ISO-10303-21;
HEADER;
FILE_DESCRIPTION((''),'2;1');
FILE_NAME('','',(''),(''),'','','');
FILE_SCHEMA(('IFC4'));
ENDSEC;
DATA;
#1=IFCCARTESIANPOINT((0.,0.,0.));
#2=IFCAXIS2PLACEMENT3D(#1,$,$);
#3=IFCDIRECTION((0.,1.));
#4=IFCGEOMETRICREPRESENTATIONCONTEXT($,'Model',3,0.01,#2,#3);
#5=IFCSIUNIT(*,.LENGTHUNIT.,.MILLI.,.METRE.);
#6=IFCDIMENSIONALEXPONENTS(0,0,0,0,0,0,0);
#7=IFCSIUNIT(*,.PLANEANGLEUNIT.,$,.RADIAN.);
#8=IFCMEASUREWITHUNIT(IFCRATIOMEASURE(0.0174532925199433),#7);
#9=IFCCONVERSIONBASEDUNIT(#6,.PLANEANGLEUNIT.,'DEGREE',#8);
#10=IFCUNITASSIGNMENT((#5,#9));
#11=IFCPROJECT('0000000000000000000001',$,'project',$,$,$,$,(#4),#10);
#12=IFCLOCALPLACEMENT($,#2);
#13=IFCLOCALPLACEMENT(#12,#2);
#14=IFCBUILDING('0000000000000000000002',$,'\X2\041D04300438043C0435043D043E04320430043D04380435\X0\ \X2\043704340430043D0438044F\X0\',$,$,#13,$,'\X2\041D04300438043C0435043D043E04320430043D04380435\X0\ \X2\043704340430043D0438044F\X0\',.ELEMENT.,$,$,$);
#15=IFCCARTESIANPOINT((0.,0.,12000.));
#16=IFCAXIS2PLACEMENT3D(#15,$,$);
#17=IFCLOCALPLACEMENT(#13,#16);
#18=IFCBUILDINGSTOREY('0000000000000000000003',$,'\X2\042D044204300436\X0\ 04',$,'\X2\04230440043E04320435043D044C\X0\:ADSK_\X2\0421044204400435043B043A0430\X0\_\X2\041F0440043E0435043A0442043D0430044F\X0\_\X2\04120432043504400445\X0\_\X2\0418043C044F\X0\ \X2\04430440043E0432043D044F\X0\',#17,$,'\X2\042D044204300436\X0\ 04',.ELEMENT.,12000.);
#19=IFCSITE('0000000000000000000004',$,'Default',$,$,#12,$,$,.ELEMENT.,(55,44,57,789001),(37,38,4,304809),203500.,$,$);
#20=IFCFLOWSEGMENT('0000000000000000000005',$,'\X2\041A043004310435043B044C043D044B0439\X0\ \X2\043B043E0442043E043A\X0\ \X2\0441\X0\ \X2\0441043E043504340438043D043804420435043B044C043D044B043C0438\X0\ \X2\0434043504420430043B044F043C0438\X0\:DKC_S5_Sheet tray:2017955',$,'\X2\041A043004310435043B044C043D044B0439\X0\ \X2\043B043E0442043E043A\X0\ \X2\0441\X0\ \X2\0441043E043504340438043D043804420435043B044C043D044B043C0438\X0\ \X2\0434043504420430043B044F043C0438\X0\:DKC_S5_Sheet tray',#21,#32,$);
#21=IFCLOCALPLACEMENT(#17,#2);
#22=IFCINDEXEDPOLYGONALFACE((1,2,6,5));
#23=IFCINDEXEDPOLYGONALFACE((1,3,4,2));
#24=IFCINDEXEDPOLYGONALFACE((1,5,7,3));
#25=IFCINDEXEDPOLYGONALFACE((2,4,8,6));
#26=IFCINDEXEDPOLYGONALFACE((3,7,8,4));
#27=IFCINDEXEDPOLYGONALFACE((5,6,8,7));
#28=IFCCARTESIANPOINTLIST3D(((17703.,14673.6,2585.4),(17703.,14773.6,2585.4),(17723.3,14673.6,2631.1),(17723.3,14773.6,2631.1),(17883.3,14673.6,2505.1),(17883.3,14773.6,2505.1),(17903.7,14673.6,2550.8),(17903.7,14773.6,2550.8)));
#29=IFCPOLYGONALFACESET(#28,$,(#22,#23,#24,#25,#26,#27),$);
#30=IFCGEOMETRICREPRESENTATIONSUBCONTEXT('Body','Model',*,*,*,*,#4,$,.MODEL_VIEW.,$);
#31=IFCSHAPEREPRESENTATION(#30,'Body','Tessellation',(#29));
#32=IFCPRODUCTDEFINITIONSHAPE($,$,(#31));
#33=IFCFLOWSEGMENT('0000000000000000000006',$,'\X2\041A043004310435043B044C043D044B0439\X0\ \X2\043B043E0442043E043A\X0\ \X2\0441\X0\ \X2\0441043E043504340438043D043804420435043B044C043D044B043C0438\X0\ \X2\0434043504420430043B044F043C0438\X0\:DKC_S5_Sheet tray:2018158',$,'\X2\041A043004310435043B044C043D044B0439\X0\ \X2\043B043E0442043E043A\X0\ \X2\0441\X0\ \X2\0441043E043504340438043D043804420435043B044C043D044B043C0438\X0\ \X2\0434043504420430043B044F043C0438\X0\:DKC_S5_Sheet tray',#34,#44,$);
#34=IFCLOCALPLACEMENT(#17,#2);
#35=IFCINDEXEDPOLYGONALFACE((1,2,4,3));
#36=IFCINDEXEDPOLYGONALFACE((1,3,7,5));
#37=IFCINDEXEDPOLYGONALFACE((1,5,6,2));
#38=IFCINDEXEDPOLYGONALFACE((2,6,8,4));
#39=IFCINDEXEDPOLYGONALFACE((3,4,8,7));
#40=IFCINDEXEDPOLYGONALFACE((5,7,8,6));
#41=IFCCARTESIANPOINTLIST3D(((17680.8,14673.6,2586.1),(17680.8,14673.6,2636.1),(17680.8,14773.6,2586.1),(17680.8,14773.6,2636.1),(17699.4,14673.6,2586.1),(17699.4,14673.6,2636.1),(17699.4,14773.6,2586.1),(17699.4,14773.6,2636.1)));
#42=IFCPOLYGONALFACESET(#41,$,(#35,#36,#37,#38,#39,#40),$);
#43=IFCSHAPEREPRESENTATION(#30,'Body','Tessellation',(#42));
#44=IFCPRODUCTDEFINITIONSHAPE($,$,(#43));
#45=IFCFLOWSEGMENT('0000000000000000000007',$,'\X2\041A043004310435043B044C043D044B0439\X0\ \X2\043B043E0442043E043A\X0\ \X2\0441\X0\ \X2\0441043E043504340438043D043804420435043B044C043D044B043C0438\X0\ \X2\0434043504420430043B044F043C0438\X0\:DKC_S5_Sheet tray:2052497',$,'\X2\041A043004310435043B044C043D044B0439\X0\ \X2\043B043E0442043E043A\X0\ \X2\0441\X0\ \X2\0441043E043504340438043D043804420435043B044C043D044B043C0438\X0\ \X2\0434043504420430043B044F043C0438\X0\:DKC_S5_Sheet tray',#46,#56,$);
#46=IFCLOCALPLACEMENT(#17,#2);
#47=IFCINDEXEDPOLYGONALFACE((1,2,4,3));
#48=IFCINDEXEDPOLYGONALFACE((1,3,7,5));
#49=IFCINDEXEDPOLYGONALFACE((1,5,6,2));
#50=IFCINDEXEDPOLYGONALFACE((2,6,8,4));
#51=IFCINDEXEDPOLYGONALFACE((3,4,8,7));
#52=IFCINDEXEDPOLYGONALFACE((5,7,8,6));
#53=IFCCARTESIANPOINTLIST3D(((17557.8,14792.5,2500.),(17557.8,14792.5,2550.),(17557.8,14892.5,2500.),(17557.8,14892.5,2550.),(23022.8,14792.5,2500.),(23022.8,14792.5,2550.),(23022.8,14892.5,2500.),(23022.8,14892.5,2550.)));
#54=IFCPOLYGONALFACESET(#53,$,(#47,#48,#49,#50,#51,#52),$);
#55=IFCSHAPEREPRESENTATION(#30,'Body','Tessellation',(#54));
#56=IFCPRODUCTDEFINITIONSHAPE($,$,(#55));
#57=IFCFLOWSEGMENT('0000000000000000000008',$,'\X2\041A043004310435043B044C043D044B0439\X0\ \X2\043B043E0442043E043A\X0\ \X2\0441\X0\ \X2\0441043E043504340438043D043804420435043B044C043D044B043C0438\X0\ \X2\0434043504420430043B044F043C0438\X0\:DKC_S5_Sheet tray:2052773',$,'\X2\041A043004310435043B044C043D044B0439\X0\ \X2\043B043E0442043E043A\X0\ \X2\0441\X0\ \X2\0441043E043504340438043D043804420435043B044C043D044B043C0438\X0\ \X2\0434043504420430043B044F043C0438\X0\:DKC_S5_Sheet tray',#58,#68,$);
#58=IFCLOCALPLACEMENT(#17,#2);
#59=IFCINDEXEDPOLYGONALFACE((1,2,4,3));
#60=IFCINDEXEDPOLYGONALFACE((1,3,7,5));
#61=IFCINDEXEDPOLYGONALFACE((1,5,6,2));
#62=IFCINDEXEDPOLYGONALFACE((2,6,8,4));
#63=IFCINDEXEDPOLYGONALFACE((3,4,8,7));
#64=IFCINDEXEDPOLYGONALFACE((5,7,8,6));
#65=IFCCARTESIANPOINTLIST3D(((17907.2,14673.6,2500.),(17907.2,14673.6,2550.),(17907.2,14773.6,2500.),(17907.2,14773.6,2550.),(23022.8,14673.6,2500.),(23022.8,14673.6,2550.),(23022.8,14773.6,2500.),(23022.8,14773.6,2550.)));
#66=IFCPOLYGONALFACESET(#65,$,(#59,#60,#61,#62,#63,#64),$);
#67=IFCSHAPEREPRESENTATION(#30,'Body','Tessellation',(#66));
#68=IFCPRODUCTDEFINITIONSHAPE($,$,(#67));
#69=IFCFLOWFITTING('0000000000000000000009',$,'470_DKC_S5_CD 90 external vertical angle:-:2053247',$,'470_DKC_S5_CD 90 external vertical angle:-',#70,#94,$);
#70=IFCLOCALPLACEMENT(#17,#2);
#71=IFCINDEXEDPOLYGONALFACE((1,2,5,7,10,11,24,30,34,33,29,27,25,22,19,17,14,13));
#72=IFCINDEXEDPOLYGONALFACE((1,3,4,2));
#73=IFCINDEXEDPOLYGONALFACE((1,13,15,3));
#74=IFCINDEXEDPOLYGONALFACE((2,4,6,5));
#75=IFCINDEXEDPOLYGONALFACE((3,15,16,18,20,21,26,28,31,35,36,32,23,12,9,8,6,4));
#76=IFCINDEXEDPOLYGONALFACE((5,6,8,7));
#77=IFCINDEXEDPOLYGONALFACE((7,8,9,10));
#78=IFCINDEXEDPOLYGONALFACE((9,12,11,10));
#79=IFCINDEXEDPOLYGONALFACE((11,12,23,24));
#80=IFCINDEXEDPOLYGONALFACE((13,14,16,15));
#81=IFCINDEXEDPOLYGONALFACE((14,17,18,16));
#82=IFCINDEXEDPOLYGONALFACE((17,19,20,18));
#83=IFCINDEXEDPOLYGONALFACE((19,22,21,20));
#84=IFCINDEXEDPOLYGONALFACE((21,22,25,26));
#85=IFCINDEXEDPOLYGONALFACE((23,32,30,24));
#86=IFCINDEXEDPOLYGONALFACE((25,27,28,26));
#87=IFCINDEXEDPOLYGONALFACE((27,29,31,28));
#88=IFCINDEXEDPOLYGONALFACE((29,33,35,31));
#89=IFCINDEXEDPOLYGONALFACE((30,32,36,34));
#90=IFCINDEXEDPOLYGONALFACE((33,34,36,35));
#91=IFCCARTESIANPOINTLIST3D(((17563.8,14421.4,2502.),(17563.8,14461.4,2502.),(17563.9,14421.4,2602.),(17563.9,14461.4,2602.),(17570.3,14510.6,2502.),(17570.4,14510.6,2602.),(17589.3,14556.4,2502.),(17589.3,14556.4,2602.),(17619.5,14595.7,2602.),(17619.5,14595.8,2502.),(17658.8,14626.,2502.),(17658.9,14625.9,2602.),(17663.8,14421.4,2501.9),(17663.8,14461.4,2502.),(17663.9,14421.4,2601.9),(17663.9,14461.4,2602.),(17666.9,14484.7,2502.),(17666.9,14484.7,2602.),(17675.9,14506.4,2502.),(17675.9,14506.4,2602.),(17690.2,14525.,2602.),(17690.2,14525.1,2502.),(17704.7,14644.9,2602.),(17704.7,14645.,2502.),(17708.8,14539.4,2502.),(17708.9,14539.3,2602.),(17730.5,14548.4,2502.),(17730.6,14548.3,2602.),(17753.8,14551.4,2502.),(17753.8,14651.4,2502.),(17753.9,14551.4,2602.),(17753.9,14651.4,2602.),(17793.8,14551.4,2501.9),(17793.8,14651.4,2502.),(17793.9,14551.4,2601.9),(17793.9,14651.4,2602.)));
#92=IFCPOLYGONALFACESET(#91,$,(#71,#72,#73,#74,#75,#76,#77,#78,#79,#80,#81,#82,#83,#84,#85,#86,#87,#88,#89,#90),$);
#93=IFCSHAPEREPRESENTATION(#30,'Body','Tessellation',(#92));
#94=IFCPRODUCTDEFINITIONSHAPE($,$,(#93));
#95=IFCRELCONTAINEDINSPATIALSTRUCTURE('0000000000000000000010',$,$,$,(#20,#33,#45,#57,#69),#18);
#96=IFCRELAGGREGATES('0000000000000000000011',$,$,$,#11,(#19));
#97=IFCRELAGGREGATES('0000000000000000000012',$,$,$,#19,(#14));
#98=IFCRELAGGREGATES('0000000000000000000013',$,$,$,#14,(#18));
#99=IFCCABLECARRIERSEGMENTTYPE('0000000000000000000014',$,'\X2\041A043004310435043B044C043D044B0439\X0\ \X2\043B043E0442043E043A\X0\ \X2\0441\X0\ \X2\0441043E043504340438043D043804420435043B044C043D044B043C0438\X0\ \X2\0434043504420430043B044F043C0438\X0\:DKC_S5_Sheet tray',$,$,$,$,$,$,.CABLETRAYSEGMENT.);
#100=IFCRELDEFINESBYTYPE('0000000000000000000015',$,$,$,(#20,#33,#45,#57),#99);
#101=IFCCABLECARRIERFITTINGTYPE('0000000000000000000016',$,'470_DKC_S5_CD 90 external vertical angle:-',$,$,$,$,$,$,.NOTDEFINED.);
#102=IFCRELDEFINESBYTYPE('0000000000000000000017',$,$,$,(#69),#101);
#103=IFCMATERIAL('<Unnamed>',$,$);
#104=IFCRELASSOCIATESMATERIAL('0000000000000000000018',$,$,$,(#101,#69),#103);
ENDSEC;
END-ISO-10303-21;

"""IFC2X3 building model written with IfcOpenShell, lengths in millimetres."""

from ifc_helpers import new_model, entity, si_unit, converted_unit, direction, frame, frame_2d, origin, origin_2d_with_axis, place, context, subcontext, project, spatial, polyline, circle_curve, parameter, trimmed, segment, composite_curve, rectangle, outline, extrude, source, transform, mapped, material, type_object, type_shapes, element, save


model = new_model("IFC2X3")

# Units and contexts
model_context = context("Model", 3, precision=0.01, world=origin(), true_north=direction((0.0, 1.0)))
body_context = subcontext(model_context, "Body", "Model", "MODEL_VIEW")
ifc_project = project(units=[si_unit("LENGTHUNIT", "METRE", prefix="MILLI"), converted_unit("PLANEANGLEUNIT", "DEGREE", entity("IfcRatioMeasure", 0.0174532925199433), si_unit("PLANEANGLEUNIT", "RADIAN"), dimensions=[0, 0, 0, 0, 0, 0, 0])], contexts=[model_context])

# Site, building, storey
site_placement = place(None, origin())
site = spatial("IfcSite", under=ifc_project, at=site_placement, Name="Default", CompositionType="ELEMENT", RefLatitude=(55, 44, 57, 789001), RefLongitude=(37, 38, 4, 304809), RefElevation=203500.0)
building_placement = place(site_placement, origin())
building = spatial("IfcBuilding", under=site, at=building_placement, Name="Наименование здания", LongName="Наименование здания", CompositionType="ELEMENT")
storey_placement = place(building_placement, frame((0.0, 0.0, 12000.0)))
storey = spatial("IfcBuildingStorey", under=building, at=storey_placement, Name="Этаж 04", ObjectType="Уровень:ADSK_Стрелка_Проектная_Вверх_Имя уровня", LongName="Этаж 04", CompositionType="ELEMENT", Elevation=12000.0)

# Flow segments
cable_carrier_segment_type = type_object("IfcCableCarrierSegmentType", Name="Кабельный лоток с соединительными деталями:DKC_S5_Sheet tray", PredefinedType="CABLETRAYSEGMENT")
flow_segment_1_placement = place(storey_placement, frame((17703.0, 14673.6, 2505.1)))
element("IfcFlowSegment", 1, at=flow_segment_1_placement, inside=storey, type_object=cable_carrier_segment_type, Name="Кабельный лоток с соединительными деталями:DKC_S5_Sheet tray:2017955", ObjectType="Кабельный лоток с соединительными деталями:DKC_S5_Sheet tray", context=body_context, shape_type="SweptSolid", body=[
    extrude(rectangle(XDim=50.0, YDim=100.0, at=origin_2d_with_axis()), frame((10.2, 50.0, 103.1), z_axis=(0.913545, 0.0, -0.406737), x_axis=(0.406737, 0.0, 0.913545)), (0.0, 0.0, 1.0), 197.4),
])
flow_segment_2_placement = place(storey_placement, frame((17680.8, 14673.6, 2586.1)))
element("IfcFlowSegment", 2, at=flow_segment_2_placement, inside=storey, type_object=cable_carrier_segment_type, Name="Кабельный лоток с соединительными деталями:DKC_S5_Sheet tray:2018158", ObjectType="Кабельный лоток с соединительными деталями:DKC_S5_Sheet tray", context=body_context, shape_type="SweptSolid", body=[
    extrude(rectangle(XDim=18.6, YDim=100.0, at=origin_2d_with_axis()), frame((9.3, 50.0, 0.0), z_axis=(0.0, 0.0, 1.0), x_axis=(-1.0, 0.0, 0.0)), (0.0, 0.0, 1.0), 50.0),
])
flow_segment_3_placement = place(storey_placement, frame((17557.8, 14792.5, 2500.0)))
element("IfcFlowSegment", 3, at=flow_segment_3_placement, inside=storey, type_object=cable_carrier_segment_type, Name="Кабельный лоток с соединительными деталями:DKC_S5_Sheet tray:2052497", ObjectType="Кабельный лоток с соединительными деталями:DKC_S5_Sheet tray", context=body_context, shape_type="SweptSolid", body=[
    extrude(rectangle(XDim=5465.1, YDim=100.0, at=origin_2d_with_axis()), frame((2732.5, 50.0, 0.0)), (0.0, 0.0, 1.0), 50.0),
])
flow_segment_4_placement = place(storey_placement, frame((17907.2, 14673.6, 2500.0)))
element("IfcFlowSegment", 4, at=flow_segment_4_placement, inside=storey, type_object=cable_carrier_segment_type, Name="Кабельный лоток с соединительными деталями:DKC_S5_Sheet tray:2052773", ObjectType="Кабельный лоток с соединительными деталями:DKC_S5_Sheet tray", context=body_context, shape_type="SweptSolid", body=[
    extrude(rectangle(XDim=5115.6, YDim=100.0, at=origin_2d_with_axis()), frame((2557.8, 50.0, 0.0)), (0.0, 0.0, 1.0), 50.0),
])

# Flow fitting
ifc_material_1 = material(Name="<Unnamed>")
cable_carrier_fitting_type_1 = type_object("IfcCableCarrierFittingType", Name="470_DKC_S5_CD 90 external vertical angle:-", PredefinedType="NOTDEFINED", material=ifc_material_1)
shared_shape_1 = source(origin(), body_context, "Body", "SweptSolid", [
    extrude(outline(composite_curve([segment(polyline([(-100.0, -130.0), (-60.0, -130.0)]), True, "CONTINUOUS"), segment(trimmed(circle_curve(frame_2d((-60.0, 60.0), x_axis=(0.0, -1.0)), 190.0), [parameter(0.0)], [parameter(90.0)], True, "PARAMETER"), True, "CONTINUOUS"), segment(polyline([(130.0, 60.0), (130.0, 100.0)]), True, "CONTINUOUS"), segment(polyline([(130.0, 100.0), (30.0, 100.0)]), True, "CONTINUOUS"), segment(polyline([(30.0, 100.0), (30.0, 60.0)]), True, "CONTINUOUS"), segment(trimmed(circle_curve(frame_2d((-60.0, 60.0), x_axis=(0.0, -1.0)), 90.0), [parameter(0.0)], [parameter(90.0)], True, "PARAMETER"), False, "CONTINUOUS"), segment(polyline([(-60.0, -30.0), (-100.0, -30.0)]), True, "CONTINUOUS"), segment(polyline([(-100.0, -30.0), (-100.0, -130.0)]), True, "CONTINUOUS")], self_intersect=False)), frame((-80.0, 80.0, -50.0)), (0.0, 0.0, 1.0), 100.0),
])
type_shapes(cable_carrier_fitting_type_1, [shared_shape_1])
flow_fitting_1_placement = place(storey_placement, frame((17613.9, 14601.4, 2552.0), z_axis=(0.000378, -0.000473, 1.0), x_axis=(-1.0, 0.0, 0.000378)))
element("IfcFlowFitting", 5, at=flow_fitting_1_placement, inside=storey, type_object=cable_carrier_fitting_type_1, material=ifc_material_1, Name="470_DKC_S5_CD 90 external vertical angle:-:2053247", ObjectType="470_DKC_S5_CD 90 external vertical angle:-", context=body_context, shape_type="MappedRepresentation", body=[
    mapped(shared_shape_1, transform((0.0, 0.0, 0.0), scale=1.0)),
])

save(model, "model.ifc")
